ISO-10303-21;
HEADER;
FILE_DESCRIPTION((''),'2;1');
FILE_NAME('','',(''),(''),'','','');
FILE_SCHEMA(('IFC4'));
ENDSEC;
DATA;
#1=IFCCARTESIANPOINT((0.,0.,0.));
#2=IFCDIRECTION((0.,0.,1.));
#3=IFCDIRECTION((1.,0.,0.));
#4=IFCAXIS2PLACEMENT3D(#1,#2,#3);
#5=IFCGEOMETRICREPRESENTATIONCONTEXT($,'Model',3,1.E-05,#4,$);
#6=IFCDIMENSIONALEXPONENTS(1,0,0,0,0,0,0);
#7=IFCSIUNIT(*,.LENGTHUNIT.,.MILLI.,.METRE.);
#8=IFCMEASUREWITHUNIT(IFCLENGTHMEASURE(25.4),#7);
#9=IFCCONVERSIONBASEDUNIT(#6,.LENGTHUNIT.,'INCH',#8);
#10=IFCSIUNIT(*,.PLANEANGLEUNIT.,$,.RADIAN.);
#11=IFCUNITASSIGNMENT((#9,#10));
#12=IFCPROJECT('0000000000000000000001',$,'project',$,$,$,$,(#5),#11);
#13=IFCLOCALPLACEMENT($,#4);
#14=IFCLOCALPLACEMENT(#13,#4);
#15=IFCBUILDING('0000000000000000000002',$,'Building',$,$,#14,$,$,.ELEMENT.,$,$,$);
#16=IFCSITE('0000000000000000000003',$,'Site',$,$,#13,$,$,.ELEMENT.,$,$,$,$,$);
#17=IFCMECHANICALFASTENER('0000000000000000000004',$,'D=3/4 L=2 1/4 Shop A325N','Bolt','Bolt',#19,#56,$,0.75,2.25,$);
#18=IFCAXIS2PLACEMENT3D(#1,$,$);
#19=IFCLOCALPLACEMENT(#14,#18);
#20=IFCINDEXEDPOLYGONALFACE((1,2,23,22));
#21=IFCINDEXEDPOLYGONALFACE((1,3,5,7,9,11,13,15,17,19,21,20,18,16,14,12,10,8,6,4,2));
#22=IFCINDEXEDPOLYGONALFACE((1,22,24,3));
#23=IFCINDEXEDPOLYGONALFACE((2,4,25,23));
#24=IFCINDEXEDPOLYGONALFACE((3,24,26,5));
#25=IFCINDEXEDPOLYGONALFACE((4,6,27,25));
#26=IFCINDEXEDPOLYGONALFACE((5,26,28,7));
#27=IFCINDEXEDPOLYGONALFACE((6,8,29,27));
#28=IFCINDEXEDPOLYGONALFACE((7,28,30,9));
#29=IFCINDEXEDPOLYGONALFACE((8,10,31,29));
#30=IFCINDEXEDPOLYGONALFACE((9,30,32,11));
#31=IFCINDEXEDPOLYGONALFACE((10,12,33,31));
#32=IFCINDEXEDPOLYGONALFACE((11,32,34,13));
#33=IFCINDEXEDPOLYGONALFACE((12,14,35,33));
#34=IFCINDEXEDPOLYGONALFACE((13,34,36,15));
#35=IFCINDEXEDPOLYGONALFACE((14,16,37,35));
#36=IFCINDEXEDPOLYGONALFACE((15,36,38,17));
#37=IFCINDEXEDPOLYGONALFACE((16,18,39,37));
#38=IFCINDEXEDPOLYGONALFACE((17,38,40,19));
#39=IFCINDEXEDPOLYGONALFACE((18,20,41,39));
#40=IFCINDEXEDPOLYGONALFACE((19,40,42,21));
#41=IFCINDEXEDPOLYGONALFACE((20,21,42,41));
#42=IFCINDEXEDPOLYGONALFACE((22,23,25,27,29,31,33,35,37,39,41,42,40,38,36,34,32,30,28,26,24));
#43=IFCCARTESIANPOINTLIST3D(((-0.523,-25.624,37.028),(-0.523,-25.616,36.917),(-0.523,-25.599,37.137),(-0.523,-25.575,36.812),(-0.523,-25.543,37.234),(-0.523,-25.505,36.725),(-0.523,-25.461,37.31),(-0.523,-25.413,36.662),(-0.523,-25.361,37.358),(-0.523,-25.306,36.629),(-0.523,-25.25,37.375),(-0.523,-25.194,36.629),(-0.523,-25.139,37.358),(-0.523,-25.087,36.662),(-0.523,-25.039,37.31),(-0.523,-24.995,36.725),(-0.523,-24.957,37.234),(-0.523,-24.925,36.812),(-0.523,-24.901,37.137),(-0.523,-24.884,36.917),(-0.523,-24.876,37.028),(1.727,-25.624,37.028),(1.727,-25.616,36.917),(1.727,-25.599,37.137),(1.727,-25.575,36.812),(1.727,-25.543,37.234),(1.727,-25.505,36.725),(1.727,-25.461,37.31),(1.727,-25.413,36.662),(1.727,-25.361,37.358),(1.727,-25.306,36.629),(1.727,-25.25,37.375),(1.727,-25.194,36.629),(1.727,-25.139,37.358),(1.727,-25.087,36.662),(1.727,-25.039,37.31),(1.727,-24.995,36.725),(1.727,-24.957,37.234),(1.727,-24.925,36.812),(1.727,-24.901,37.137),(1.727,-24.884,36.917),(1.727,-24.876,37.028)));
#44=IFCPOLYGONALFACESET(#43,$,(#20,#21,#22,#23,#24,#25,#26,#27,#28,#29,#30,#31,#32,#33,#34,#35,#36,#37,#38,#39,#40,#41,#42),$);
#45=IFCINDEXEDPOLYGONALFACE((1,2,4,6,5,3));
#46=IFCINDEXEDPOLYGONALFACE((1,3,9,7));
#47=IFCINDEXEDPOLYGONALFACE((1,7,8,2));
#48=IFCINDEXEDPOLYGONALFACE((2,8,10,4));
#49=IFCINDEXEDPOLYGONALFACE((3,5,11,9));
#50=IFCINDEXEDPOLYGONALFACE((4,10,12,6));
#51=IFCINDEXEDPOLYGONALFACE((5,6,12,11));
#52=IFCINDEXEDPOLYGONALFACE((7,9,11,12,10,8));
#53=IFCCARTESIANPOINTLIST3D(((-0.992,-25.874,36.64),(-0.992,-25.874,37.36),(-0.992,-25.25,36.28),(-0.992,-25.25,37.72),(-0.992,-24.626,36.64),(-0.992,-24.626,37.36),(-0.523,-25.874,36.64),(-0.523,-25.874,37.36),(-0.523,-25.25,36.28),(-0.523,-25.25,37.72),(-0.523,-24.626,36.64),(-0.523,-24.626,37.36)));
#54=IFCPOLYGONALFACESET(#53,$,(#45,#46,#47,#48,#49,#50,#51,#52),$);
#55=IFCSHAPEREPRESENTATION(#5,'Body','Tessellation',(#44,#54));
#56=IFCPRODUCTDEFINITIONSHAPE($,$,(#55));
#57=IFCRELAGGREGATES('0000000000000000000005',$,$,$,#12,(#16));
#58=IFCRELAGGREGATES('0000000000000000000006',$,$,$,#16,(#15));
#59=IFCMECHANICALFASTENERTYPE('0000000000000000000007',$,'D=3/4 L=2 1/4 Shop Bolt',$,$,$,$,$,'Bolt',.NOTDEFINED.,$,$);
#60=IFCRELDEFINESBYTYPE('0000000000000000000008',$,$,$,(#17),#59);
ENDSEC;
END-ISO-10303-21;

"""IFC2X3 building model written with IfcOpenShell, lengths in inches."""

from ifc_helpers import new_model, entity, si_unit, converted_unit, frame, origin_with_axes, origin_2d_with_axis, place, context, project, spatial, polyline, circle, outline, extrude, source, transform, mapped, type_object, type_shapes, element, save


model = new_model("IFC2X3")

# Units and contexts
model_context = context("Model", 3, precision=1e-05, world=origin_with_axes())
ifc_project = project(units=[converted_unit("LENGTHUNIT", "INCH", entity("IfcLengthMeasure", 25.4), si_unit("LENGTHUNIT", "METRE", prefix="MILLI"), dimensions=[1, 0, 0, 0, 0, 0, 0]), si_unit("PLANEANGLEUNIT", "RADIAN")], contexts=[model_context])

# Site, building
site_placement = place(None, origin_with_axes())
site = spatial("IfcSite", under=ifc_project, at=site_placement, Name="Site", CompositionType="ELEMENT")
building_placement = place(site_placement, origin_with_axes())
building = spatial("IfcBuilding", under=site, at=building_placement, Name="Building", CompositionType="ELEMENT")

# Mechanical fastener
placement_1 = place(building_placement, frame((0.0, 0.0, 46.0), z_axis=(0.0, 0.0, 1.0), x_axis=(0.0, -1.0, 0.0)))
mechanical_fastener_type_1 = type_object("IfcMechanicalFastenerType", Name="D=3/4 L=2 1/4 Shop Bolt", ElementType="Bolt")
shared_shape_1 = source(origin_with_axes(), model_context, "Body", "SweptSolid", [
    extrude(circle(Radius=0.375, at=origin_2d_with_axis()), frame((0.0, 0.0, 0.0), z_axis=(1.0, 0.0, 0.0), x_axis=(0.0, 1.0, 0.0)), (0.0, 0.0, 1.0), 2.25),
    extrude(outline(polyline([(-0.72, 0.0), (-0.36, 0.624), (0.36, 0.624), (0.72, 0.0), (0.36, -0.624), (-0.36, -0.624), (-0.72, 0.0)])), frame((0.0, 0.0, 0.0), z_axis=(1.0, 0.0, 0.0), x_axis=(0.0, 1.0, 0.0)), (0.0, 0.0, -1.0), 0.47),
])
type_shapes(mechanical_fastener_type_1, [shared_shape_1])
placement_2 = place(placement_1, frame((25.25, -0.523, -3.0), z_axis=(1.0, 0.0, 0.0), x_axis=(0.0, 1.0, 0.0)))
for number, where, z_axis, x_axis, name in (
    (1, (0.0, -6.0, 0.0), (0.0, 0.0, 1.0), (1.0, 0.0, 0.0), "D=3/4 L=2 1/4 Shop A325N"),
):
    element("IfcMechanicalFastener", number, at=place(placement_2, frame(where, z_axis=z_axis, x_axis=x_axis)), type_object=mechanical_fastener_type_1, Name=name, Description="Bolt", ObjectType="Bolt", NominalDiameter=0.75, NominalLength=2.25, context=model_context, shape_type="MappedRepresentation", body=[
        mapped(shared_shape_1, transform((0.0, 0.0, 0.0), scale=1.0)),
    ])

save(model, "model.ifc")
